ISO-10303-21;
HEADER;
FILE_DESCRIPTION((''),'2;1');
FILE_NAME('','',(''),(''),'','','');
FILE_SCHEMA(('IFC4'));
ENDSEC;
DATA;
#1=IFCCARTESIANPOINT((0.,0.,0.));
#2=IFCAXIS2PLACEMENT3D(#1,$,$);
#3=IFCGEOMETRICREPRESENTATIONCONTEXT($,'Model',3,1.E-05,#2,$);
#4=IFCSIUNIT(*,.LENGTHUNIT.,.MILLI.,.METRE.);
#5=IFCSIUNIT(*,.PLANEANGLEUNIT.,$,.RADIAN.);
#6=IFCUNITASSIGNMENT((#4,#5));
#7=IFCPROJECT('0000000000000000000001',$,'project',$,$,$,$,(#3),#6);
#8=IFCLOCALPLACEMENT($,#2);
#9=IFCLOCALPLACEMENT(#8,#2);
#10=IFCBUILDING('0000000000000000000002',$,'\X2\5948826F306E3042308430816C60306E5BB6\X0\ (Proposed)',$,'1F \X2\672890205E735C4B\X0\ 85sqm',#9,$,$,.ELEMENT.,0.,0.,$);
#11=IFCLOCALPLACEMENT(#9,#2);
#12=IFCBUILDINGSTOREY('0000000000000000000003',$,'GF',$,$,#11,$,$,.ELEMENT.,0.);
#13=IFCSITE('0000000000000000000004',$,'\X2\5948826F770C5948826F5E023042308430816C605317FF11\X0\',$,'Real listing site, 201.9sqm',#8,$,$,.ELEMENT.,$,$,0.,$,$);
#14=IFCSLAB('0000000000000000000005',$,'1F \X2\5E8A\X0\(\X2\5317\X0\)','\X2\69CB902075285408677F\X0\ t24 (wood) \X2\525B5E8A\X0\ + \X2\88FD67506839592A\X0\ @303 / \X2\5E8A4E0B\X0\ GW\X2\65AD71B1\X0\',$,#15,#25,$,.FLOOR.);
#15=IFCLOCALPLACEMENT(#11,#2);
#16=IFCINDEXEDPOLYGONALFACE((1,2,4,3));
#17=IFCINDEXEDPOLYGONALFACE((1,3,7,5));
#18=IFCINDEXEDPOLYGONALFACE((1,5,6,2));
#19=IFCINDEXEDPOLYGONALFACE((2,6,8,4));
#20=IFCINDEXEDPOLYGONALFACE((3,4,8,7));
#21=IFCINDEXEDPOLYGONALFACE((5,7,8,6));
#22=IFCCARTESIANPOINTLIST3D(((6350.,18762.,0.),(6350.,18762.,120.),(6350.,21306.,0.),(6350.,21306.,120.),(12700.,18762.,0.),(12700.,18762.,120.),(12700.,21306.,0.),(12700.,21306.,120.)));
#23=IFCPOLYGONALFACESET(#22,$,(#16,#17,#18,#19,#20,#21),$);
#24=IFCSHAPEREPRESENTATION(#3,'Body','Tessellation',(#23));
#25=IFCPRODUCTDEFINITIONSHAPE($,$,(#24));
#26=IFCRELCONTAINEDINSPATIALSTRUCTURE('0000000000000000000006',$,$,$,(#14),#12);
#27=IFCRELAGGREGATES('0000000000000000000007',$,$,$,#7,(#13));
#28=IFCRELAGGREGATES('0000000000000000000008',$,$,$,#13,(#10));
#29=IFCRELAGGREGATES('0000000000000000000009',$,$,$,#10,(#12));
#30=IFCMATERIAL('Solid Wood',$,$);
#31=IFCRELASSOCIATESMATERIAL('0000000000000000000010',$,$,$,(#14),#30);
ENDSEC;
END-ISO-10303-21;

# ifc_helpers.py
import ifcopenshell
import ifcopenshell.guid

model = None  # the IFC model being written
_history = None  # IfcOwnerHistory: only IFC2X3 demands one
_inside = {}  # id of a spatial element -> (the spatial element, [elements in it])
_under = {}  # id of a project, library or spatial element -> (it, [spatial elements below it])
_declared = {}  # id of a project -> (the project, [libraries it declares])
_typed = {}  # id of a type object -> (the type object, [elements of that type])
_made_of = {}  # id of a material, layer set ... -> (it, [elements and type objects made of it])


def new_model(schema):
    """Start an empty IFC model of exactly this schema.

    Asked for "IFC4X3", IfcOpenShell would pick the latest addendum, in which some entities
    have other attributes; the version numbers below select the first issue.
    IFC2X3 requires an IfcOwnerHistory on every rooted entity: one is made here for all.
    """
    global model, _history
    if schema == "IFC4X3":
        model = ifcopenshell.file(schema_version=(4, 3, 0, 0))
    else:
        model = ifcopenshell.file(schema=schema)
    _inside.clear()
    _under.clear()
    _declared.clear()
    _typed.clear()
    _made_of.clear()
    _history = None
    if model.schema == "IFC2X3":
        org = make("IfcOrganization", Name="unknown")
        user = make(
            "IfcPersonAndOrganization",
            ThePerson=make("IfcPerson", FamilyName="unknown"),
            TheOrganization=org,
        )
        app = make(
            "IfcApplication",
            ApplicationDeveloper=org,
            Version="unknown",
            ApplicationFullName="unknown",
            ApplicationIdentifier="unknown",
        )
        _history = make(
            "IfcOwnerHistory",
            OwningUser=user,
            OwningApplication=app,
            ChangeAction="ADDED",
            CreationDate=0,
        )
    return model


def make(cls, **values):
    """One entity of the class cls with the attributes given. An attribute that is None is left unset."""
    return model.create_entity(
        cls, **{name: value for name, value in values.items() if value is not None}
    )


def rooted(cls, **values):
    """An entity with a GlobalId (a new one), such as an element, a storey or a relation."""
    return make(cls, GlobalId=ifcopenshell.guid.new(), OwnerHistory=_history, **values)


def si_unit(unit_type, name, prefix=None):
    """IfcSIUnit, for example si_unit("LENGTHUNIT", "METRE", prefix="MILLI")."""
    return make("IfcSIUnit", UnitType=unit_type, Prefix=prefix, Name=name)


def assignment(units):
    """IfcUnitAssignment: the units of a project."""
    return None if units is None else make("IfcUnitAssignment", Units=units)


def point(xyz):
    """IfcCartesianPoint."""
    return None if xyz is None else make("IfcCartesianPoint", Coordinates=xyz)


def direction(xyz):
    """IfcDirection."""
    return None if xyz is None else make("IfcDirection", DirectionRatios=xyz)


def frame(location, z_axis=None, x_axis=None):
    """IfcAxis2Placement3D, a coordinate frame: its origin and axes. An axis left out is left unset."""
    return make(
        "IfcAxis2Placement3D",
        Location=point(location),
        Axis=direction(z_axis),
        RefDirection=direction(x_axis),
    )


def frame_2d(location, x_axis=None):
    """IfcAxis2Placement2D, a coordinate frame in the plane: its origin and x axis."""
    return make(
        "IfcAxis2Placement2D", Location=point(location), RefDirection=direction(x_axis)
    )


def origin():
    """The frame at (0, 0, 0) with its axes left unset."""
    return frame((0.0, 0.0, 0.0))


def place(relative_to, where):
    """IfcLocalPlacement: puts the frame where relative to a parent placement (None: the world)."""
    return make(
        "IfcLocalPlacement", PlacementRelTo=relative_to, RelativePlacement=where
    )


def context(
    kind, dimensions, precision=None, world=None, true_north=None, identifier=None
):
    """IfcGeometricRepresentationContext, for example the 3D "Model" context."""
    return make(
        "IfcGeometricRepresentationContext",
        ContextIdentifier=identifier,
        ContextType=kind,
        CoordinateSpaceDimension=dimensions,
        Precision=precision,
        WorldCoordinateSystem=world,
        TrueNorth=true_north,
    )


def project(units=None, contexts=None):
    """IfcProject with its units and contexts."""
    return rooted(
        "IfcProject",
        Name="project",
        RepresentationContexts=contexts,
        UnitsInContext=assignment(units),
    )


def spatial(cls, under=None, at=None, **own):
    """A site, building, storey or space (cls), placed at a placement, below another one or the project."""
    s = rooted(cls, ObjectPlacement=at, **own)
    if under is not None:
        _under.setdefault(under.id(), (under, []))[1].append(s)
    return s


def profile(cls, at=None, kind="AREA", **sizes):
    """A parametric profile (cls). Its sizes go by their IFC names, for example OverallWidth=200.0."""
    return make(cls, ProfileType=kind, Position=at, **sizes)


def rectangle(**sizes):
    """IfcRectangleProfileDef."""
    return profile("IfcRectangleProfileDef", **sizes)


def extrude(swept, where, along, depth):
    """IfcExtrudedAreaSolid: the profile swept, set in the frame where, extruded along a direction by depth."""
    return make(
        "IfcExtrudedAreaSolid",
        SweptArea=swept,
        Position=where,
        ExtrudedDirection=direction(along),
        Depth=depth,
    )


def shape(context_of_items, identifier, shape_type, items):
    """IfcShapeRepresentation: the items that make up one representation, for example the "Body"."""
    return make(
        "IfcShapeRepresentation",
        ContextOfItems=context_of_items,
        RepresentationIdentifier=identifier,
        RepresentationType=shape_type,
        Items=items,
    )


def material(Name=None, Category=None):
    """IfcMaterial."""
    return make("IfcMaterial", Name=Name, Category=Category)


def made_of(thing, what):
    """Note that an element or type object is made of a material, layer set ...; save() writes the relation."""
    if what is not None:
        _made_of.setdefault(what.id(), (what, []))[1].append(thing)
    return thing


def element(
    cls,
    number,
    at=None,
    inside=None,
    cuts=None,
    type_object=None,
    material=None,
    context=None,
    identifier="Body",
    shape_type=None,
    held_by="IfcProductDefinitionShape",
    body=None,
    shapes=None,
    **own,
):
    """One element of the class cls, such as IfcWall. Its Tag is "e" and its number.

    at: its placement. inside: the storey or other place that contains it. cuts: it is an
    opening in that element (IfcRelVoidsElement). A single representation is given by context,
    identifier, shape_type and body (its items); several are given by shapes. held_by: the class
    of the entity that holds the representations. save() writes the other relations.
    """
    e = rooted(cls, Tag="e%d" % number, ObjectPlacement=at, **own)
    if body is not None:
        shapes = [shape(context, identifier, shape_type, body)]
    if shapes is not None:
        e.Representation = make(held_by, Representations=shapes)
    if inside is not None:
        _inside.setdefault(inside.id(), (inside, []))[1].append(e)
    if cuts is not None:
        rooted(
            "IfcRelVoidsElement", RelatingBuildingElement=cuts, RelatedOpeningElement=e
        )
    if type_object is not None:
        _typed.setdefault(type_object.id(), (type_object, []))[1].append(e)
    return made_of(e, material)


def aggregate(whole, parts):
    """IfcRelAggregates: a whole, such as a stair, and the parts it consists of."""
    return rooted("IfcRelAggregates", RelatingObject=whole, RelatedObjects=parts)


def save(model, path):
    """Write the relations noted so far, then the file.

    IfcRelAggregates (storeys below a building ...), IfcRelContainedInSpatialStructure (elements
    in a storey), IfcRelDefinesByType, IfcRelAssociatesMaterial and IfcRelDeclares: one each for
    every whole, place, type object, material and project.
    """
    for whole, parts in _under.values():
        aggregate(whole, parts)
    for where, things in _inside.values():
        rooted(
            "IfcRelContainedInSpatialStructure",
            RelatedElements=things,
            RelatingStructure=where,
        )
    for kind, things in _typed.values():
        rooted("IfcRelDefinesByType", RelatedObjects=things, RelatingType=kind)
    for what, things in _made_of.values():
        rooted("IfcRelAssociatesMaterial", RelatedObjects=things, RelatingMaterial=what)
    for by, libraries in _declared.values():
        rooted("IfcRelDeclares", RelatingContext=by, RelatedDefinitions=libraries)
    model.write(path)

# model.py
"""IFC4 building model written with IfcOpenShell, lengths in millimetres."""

from ifc_helpers import new_model, si_unit, frame, frame_2d, origin, place, context, project, spatial, rectangle, extrude, material, element, save


model = new_model("IFC4")

# Units and contexts
model_context = context("Model", 3, precision=1e-05, world=origin())
ifc_project = project(units=[si_unit("LENGTHUNIT", "METRE", prefix="MILLI"), si_unit("PLANEANGLEUNIT", "RADIAN")], contexts=[model_context])

# Site, building, storey
site_placement = place(None, origin())
site = spatial("IfcSite", under=ifc_project, at=site_placement, Name="奈良県奈良市あやめ池北１", ObjectType="Real listing site, 201.9sqm", CompositionType="ELEMENT", RefElevation=0.0)
building_placement = place(site_placement, origin())
building = spatial("IfcBuilding", under=site, at=building_placement, Name="奈良のあやめ池の家 (Proposed)", ObjectType="1F 木造平屋 85sqm", CompositionType="ELEMENT", ElevationOfRefHeight=0.0, ElevationOfTerrain=0.0)
storey_placement = place(building_placement, origin())
storey = spatial("IfcBuildingStorey", under=building, at=storey_placement, Name="GF", CompositionType="ELEMENT", Elevation=0.0)

# Slab
ifc_material_1 = material(Name="Solid Wood")
slab_1_placement = place(storey_placement, frame((3175.0, 9381.0, 0.0)))
element("IfcSlab", 1, at=slab_1_placement, inside=storey, material=ifc_material_1, Name="1F 床(北)", Description="構造用合板 t24 (wood) 剛床 + 製材根太 @303 / 床下 GW断熱", PredefinedType="FLOOR", context=model_context, shape_type="SweptSolid", body=[
    extrude(rectangle(XDim=6350.0, YDim=2544.0, at=frame_2d((3175.0, 1272.0))), frame((3175.0, 9381.0, 0.0)), (0.0, 0.0, 1.0), 120.0),
])

save(model, "model.ifc")
